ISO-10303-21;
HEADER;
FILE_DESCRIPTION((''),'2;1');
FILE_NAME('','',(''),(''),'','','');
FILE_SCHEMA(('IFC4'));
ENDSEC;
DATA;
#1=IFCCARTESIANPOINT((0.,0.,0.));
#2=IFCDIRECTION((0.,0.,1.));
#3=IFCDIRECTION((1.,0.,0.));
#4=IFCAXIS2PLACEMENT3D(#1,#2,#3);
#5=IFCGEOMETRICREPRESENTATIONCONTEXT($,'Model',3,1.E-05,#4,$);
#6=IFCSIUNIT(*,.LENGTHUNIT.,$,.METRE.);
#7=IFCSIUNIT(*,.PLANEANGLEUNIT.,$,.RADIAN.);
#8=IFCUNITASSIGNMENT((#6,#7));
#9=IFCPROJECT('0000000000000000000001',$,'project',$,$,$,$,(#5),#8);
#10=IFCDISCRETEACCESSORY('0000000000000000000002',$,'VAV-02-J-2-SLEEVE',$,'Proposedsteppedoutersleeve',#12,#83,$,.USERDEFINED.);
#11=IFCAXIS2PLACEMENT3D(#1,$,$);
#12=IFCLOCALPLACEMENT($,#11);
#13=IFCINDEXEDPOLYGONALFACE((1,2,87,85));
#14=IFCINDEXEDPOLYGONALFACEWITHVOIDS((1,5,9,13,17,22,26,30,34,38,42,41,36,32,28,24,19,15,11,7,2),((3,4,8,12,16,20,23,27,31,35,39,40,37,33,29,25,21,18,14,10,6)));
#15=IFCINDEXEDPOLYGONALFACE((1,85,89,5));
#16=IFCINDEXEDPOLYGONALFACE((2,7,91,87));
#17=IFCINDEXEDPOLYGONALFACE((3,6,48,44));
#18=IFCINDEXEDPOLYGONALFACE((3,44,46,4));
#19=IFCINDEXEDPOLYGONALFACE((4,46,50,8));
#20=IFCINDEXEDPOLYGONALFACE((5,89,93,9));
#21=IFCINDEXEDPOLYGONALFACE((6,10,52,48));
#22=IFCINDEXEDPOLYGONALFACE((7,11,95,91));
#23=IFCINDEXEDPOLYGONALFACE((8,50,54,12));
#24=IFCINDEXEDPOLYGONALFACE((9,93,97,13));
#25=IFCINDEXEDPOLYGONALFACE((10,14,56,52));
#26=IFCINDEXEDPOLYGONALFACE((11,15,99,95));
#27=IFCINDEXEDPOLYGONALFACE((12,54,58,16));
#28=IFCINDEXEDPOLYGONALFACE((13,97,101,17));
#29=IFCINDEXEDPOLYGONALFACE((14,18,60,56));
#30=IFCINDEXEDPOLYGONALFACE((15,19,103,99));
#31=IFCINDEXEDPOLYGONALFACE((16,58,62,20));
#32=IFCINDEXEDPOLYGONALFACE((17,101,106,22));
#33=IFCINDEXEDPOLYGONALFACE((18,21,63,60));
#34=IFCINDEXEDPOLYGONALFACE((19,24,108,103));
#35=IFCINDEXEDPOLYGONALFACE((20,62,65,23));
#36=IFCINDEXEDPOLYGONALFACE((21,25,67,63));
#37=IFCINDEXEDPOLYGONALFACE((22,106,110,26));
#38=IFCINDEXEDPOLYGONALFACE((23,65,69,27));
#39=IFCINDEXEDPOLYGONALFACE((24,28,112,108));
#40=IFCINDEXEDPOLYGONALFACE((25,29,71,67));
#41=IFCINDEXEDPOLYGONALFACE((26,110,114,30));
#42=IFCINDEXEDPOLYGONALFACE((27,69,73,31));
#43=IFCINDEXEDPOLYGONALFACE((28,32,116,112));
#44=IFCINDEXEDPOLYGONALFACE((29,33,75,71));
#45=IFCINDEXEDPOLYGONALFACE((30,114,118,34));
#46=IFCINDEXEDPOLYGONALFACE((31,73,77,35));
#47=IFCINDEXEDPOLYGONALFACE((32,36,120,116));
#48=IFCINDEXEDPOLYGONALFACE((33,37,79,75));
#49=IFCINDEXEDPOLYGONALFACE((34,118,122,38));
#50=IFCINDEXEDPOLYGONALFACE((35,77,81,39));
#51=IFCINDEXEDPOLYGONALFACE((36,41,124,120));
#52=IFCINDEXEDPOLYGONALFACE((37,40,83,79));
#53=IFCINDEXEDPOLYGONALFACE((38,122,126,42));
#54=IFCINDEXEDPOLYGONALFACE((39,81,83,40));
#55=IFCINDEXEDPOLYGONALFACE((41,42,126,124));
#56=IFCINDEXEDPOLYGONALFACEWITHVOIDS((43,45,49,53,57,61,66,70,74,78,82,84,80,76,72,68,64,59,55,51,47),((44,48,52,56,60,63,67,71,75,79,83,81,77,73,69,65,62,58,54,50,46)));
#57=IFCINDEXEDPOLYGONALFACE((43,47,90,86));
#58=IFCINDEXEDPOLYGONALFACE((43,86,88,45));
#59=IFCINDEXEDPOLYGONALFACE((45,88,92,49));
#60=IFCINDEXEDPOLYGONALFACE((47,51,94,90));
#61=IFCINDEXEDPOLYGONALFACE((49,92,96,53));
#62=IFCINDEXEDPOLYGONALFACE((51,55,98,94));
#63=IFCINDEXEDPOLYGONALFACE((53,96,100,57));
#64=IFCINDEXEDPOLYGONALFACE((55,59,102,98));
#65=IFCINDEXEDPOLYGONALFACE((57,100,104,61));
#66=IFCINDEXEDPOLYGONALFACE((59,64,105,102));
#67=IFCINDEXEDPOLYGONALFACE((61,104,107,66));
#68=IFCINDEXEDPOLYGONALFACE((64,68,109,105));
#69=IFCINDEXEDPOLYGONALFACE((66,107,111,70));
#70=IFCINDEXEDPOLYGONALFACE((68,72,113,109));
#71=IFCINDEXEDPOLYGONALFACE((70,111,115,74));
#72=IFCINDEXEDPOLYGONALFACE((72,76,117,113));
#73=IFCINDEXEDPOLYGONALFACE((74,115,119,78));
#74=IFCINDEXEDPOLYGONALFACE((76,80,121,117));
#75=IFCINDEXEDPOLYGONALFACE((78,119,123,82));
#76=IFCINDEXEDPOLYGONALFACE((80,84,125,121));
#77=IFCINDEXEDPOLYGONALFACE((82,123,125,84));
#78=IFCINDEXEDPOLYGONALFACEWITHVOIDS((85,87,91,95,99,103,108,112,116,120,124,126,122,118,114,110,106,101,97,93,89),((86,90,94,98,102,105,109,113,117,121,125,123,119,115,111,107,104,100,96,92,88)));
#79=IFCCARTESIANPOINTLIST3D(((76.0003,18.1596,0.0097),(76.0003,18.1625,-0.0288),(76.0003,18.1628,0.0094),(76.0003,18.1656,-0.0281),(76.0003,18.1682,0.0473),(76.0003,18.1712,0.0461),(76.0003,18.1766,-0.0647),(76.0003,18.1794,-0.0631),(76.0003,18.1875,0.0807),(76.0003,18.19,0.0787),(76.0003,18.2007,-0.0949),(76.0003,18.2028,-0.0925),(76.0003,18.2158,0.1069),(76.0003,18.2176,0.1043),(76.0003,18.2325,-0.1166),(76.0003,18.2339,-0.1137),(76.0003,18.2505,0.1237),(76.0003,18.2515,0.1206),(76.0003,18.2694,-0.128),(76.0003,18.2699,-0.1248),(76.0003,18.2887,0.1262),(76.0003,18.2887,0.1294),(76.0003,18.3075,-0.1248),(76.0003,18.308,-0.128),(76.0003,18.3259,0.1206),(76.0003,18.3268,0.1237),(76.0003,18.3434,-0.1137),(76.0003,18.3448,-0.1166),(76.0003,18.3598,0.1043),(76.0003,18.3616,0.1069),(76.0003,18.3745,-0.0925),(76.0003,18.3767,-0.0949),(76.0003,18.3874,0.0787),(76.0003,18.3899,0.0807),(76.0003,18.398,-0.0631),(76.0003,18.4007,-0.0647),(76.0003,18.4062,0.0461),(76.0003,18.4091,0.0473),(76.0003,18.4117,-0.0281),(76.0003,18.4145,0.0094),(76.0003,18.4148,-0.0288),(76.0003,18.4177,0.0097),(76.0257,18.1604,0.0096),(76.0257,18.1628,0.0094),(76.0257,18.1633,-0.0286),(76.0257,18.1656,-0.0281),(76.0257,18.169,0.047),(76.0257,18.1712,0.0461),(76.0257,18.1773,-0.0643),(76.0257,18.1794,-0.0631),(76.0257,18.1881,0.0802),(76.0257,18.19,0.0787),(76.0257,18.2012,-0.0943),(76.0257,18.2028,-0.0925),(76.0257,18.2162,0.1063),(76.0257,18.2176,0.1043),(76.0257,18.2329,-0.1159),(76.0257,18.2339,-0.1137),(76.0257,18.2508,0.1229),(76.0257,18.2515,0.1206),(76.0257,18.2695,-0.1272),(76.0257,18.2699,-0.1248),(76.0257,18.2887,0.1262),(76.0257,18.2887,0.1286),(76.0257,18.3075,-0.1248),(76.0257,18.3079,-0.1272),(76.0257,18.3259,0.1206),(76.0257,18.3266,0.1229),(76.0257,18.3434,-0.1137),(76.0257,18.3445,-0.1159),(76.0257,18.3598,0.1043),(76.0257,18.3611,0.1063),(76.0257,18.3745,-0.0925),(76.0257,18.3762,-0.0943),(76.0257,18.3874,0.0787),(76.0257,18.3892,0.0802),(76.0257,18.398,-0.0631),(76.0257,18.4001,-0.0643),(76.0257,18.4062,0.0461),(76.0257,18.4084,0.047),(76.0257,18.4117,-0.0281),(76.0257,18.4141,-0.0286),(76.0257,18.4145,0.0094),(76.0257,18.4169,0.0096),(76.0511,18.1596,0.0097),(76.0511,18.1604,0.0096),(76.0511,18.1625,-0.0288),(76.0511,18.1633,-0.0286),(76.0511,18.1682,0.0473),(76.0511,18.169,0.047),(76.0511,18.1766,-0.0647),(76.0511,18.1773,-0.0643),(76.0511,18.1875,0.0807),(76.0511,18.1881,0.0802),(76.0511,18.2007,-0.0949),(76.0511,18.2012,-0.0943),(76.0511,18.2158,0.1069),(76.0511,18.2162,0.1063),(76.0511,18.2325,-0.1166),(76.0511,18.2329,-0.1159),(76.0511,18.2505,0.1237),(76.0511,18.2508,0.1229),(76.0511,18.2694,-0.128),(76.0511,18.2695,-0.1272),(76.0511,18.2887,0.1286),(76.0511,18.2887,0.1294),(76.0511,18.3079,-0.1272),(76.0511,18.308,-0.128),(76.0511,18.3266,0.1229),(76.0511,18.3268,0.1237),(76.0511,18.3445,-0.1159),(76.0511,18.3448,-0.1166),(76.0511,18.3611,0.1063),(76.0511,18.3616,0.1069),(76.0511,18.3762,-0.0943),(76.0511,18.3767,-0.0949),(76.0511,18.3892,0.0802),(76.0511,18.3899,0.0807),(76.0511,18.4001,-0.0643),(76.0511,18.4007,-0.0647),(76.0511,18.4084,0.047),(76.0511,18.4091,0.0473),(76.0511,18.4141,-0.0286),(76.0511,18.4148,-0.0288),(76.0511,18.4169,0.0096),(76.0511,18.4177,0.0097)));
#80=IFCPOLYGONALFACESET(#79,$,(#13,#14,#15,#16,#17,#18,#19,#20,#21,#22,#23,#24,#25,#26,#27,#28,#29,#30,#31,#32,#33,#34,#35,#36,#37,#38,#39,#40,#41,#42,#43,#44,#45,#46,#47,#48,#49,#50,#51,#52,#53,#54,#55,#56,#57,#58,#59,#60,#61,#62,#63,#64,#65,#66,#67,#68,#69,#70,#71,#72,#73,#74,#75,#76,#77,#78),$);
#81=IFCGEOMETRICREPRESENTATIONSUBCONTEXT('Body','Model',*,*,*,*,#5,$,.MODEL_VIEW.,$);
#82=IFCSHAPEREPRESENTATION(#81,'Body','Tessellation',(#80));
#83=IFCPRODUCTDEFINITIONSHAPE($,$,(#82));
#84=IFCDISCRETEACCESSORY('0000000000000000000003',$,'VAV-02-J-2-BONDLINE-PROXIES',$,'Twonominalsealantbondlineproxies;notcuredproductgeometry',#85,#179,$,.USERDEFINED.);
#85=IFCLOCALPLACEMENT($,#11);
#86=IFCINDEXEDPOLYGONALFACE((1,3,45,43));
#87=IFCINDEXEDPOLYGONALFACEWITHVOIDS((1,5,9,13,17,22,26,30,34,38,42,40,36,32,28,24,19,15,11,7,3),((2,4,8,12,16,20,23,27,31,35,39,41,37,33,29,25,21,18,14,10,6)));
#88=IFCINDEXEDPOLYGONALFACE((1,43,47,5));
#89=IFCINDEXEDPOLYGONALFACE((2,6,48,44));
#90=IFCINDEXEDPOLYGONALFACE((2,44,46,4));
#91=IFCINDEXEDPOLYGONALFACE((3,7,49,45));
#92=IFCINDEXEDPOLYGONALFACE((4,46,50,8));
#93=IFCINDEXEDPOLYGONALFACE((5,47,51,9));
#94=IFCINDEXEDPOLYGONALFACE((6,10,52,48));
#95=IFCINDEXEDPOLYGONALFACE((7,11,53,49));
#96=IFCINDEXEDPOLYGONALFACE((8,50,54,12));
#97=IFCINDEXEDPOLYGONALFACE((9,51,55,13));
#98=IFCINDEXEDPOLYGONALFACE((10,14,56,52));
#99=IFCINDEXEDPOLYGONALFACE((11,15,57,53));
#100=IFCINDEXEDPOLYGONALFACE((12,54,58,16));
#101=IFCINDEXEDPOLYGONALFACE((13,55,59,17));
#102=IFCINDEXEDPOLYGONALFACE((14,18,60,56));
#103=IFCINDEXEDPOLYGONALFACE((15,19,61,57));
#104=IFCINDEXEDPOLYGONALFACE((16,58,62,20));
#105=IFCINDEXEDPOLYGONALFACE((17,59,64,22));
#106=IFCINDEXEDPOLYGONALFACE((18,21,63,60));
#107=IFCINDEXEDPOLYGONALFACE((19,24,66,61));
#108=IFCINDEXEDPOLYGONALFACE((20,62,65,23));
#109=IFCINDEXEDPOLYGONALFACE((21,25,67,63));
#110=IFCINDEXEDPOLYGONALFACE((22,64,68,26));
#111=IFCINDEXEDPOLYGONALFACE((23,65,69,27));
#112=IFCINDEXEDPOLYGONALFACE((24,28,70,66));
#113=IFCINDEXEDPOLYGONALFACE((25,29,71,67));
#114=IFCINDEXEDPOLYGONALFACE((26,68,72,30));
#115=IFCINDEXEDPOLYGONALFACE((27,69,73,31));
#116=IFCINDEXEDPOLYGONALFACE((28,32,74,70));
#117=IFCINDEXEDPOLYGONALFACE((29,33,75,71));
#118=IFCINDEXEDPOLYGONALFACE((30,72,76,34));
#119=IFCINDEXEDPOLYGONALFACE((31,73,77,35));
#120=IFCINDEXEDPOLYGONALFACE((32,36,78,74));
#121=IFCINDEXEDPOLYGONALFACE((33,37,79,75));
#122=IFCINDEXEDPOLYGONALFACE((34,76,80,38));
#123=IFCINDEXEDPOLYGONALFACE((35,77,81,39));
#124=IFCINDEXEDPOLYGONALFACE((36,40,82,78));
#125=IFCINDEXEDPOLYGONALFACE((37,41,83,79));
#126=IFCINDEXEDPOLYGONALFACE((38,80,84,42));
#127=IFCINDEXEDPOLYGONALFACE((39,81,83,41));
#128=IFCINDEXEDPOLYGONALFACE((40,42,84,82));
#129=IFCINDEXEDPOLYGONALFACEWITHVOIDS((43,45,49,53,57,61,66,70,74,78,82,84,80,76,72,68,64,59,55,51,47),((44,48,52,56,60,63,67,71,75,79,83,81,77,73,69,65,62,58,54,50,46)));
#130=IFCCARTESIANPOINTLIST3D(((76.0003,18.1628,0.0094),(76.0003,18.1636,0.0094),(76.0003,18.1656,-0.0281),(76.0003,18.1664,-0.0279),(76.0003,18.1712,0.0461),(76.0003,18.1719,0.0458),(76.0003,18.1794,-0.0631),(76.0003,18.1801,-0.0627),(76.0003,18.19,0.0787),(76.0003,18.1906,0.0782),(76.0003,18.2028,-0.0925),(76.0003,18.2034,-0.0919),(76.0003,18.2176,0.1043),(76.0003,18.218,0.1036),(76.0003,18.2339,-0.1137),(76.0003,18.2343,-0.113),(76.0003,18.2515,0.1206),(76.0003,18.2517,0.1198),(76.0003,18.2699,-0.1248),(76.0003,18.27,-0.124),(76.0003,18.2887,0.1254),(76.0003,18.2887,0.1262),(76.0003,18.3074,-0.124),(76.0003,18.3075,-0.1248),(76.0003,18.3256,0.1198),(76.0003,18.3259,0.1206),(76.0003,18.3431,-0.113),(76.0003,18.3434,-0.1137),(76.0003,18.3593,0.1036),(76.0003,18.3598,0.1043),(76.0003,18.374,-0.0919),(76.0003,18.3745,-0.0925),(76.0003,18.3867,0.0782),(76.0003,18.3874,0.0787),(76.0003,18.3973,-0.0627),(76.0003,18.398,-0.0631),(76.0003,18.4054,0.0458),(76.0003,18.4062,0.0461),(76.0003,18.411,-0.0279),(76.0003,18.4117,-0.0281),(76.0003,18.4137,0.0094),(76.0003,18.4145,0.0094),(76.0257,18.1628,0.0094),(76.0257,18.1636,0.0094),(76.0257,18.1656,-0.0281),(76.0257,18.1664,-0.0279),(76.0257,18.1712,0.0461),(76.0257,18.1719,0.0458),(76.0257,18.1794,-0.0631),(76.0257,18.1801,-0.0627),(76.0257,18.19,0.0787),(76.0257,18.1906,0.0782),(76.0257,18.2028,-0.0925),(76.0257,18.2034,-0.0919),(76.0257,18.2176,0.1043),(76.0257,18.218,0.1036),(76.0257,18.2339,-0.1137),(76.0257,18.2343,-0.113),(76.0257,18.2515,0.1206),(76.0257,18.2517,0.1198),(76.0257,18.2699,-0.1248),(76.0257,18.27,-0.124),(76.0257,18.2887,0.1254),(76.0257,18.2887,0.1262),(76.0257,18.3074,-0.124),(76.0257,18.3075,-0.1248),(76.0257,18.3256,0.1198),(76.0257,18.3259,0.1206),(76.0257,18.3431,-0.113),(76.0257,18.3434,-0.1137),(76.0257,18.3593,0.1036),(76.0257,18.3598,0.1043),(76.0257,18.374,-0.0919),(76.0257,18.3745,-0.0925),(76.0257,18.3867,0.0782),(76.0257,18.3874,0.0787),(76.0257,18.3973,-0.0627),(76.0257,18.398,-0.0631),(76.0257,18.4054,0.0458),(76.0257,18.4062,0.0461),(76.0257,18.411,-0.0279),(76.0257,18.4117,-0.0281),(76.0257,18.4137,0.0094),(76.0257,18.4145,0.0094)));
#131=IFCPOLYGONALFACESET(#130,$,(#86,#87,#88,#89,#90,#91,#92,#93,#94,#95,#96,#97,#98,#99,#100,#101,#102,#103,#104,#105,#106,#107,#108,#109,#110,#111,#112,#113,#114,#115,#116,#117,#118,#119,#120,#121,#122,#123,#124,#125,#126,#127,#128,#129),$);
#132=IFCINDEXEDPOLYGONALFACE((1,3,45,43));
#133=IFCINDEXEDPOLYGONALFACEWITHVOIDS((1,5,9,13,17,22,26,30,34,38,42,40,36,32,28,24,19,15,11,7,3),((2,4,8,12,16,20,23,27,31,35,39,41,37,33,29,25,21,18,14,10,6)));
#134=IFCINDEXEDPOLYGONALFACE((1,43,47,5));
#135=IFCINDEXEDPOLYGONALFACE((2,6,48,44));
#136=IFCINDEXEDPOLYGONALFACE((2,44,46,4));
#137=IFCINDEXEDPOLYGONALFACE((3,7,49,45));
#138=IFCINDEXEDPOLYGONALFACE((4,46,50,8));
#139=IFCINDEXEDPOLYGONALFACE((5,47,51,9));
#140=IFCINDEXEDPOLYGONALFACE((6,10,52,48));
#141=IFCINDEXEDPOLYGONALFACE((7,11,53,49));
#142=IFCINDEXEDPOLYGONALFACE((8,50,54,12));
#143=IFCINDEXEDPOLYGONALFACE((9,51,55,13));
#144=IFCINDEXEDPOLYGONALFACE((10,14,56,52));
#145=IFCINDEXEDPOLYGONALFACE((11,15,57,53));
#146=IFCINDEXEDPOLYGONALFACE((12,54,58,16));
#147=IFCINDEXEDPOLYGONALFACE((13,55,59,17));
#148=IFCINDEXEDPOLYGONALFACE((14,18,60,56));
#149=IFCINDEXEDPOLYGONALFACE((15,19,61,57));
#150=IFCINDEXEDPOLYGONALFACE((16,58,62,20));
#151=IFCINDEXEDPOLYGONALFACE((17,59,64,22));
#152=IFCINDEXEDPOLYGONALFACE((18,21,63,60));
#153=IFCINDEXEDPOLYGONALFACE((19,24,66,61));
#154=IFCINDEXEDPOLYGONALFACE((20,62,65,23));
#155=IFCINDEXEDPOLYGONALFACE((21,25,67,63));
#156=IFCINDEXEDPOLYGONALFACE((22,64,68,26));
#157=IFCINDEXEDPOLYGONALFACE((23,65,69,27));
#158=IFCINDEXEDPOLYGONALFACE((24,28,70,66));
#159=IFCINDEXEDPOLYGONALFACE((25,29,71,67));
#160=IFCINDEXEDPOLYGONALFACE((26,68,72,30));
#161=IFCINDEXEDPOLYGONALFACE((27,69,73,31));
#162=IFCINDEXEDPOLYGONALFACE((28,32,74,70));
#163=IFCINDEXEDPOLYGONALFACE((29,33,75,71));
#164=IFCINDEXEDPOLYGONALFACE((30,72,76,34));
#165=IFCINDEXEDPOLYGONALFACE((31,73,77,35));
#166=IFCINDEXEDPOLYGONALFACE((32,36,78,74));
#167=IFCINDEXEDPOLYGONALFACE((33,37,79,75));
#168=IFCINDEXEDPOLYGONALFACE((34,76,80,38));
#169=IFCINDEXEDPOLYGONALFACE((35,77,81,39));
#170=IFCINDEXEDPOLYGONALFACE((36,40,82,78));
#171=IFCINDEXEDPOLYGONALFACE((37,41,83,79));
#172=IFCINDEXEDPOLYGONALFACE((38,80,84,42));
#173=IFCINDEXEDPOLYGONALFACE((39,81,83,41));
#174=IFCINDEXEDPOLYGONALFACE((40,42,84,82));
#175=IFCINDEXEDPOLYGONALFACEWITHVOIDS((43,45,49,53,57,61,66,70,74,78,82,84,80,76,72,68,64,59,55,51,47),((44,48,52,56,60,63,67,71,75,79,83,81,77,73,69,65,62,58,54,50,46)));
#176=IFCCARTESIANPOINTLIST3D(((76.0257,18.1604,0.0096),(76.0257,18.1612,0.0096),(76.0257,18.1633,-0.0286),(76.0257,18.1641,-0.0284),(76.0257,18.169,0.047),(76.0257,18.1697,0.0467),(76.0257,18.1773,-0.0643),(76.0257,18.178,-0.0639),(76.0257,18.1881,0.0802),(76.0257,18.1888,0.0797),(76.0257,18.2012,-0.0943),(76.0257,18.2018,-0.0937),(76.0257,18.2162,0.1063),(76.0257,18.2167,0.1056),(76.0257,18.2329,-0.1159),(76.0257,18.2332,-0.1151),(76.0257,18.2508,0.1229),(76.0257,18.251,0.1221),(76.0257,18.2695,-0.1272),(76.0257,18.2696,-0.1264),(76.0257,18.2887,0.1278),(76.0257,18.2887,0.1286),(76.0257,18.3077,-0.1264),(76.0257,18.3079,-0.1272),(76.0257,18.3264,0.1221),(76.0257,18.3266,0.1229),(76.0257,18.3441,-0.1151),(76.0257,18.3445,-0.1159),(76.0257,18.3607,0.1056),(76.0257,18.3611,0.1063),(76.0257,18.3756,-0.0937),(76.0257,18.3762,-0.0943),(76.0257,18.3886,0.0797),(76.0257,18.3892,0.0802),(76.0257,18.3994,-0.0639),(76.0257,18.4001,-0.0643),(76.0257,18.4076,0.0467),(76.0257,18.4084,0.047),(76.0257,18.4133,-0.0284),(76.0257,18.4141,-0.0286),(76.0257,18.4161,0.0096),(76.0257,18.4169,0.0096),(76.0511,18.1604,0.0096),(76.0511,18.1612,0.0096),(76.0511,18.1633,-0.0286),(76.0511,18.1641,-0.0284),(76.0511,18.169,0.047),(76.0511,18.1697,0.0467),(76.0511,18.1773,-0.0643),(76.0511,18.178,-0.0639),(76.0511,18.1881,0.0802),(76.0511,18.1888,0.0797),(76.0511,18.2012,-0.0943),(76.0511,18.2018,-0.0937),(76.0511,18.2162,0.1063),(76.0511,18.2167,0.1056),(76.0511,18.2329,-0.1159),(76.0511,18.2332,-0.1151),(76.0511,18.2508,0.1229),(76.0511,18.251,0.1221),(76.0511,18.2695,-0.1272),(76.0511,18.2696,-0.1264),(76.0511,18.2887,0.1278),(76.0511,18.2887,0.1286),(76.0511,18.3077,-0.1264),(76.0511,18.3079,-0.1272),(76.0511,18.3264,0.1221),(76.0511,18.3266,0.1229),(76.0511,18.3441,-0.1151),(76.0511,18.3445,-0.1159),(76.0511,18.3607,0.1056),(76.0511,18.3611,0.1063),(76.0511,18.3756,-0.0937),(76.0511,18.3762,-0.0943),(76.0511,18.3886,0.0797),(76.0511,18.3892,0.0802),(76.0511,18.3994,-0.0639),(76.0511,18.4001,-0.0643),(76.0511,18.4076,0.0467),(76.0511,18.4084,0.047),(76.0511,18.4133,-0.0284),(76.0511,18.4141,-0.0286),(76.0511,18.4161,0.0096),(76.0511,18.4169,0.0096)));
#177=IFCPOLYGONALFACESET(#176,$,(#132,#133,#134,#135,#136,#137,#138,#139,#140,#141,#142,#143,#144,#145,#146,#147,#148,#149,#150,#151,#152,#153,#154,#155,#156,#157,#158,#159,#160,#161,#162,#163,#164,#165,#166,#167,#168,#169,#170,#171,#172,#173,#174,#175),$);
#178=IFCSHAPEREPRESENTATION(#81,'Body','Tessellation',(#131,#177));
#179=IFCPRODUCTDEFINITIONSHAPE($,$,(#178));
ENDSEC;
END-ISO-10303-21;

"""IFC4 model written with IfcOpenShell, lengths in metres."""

from ifc_helpers import new_model, entity, si_unit, frame, origin_with_axes, place, context, subcontext, project, element, save


model = new_model("IFC4")

# Units and contexts
model_context = context("Model", 3, precision=1e-05, world=origin_with_axes())
body_context = subcontext(model_context, "Body", "Model", "MODEL_VIEW")
ifc_project = project(units=[si_unit("LENGTHUNIT", "METRE"), si_unit("PLANEANGLEUNIT", "RADIAN")], contexts=[model_context])

# Discrete accessories
discrete_accessory_1_placement = place(None, frame((76.0257, 18.2887, 0.0), z_axis=(0.0, 1.0, 0.0), x_axis=(0.0, 0.0, 1.0)))
element("IfcDiscreteAccessory", 1, at=discrete_accessory_1_placement, Name="VAV-02-J-2-SLEEVE", ObjectType="Proposedsteppedoutersleeve", PredefinedType="USERDEFINED", context=body_context, shape_type="SweptSolid", body=[
    entity("IfcRevolvedAreaSolid", entity("IfcArbitraryClosedProfileDef", "AREA", None, entity("IfcPolyline", [entity("IfcCartesianPoint", [0.1262, -0.0254]), entity("IfcCartesianPoint", [0.1294, -0.0254]), entity("IfcCartesianPoint", [0.1294, 0.0254]), entity("IfcCartesianPoint", [0.1286, 0.0254]), entity("IfcCartesianPoint", [0.1286, 0.0]), entity("IfcCartesianPoint", [0.1262, 0.0]), entity("IfcCartesianPoint", [0.1262, -0.0254])])), entity("IfcAxis2Placement3D", entity("IfcCartesianPoint", [0.0, 0.0, 0.0])), entity("IfcAxis1Placement", entity("IfcCartesianPoint", [0.0, 0.0, 0.0]), entity("IfcDirection", [0.0, 1.0, 0.0])), 6.283185),
])
discrete_accessory_2_placement = place(None, frame((76.0257, 18.2887, 0.0), z_axis=(0.0, 1.0, 0.0), x_axis=(0.0, 0.0, 1.0)))
element("IfcDiscreteAccessory", 2, at=discrete_accessory_2_placement, Name="VAV-02-J-2-BONDLINE-PROXIES", ObjectType="Twonominalsealantbondlineproxies;notcuredproductgeometry", PredefinedType="USERDEFINED", context=body_context, shape_type="SweptSolid", body=[
    entity("IfcRevolvedAreaSolid", entity("IfcArbitraryClosedProfileDef", "AREA", None, entity("IfcPolyline", [entity("IfcCartesianPoint", [0.1254, -0.0254]), entity("IfcCartesianPoint", [0.1262, -0.0254]), entity("IfcCartesianPoint", [0.1262, 0.0]), entity("IfcCartesianPoint", [0.1254, 0.0]), entity("IfcCartesianPoint", [0.1254, -0.0254])])), entity("IfcAxis2Placement3D", entity("IfcCartesianPoint", [0.0, 0.0, 0.0])), entity("IfcAxis1Placement", entity("IfcCartesianPoint", [0.0, 0.0, 0.0]), entity("IfcDirection", [0.0, 1.0, 0.0])), 6.283185),
    entity("IfcRevolvedAreaSolid", entity("IfcArbitraryClosedProfileDef", "AREA", None, entity("IfcPolyline", [entity("IfcCartesianPoint", [0.1278, 0.0]), entity("IfcCartesianPoint", [0.1286, 0.0]), entity("IfcCartesianPoint", [0.1286, 0.0254]), entity("IfcCartesianPoint", [0.1278, 0.0254]), entity("IfcCartesianPoint", [0.1278, 0.0])])), entity("IfcAxis2Placement3D", entity("IfcCartesianPoint", [0.0, 0.0, 0.0])), entity("IfcAxis1Placement", entity("IfcCartesianPoint", [0.0, 0.0, 0.0]), entity("IfcDirection", [0.0, 1.0, 0.0])), 6.283185),
])

save(model, "model.ifc")
